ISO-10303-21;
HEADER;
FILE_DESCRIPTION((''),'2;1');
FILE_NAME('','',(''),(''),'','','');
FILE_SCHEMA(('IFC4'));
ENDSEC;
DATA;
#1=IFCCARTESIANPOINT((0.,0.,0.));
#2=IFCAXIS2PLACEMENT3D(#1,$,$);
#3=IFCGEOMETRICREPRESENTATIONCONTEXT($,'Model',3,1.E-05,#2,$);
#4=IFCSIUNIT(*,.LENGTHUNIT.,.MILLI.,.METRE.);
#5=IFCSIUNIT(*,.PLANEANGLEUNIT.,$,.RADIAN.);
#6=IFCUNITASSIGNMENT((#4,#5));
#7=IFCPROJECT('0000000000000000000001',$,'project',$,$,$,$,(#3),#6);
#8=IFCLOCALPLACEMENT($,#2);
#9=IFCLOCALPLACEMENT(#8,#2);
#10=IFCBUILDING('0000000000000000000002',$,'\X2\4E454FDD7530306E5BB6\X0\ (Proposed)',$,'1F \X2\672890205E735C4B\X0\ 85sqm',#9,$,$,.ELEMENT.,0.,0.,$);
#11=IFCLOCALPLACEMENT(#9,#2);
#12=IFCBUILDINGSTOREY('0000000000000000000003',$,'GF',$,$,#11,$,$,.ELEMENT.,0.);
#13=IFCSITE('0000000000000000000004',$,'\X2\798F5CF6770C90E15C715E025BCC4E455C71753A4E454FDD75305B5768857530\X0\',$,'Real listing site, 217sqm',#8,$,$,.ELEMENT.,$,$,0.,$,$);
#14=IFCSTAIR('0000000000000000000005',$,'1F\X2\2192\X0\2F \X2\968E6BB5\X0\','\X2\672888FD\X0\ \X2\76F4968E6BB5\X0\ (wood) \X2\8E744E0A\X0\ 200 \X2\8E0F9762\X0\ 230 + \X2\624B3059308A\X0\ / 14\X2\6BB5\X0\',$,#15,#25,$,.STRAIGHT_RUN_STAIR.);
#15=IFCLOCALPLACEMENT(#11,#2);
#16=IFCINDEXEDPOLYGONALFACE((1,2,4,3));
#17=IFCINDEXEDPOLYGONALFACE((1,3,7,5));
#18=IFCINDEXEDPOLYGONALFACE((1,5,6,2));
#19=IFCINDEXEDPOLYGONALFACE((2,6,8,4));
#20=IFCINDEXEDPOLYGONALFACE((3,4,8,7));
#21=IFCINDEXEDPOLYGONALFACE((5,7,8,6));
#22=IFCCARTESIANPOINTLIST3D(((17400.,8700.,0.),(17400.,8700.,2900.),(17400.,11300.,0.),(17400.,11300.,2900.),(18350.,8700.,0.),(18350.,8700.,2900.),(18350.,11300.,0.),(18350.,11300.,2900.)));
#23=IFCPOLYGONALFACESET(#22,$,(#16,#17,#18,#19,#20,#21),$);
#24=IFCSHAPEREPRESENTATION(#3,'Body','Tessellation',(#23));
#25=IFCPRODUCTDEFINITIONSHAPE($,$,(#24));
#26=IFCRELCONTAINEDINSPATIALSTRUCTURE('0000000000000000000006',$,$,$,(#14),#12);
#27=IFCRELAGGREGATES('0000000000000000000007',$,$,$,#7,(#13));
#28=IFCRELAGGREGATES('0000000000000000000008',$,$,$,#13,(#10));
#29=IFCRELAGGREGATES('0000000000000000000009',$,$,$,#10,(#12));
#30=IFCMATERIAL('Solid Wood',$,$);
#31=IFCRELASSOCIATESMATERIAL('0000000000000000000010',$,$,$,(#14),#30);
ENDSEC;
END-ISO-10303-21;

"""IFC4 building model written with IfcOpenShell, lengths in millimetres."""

from ifc_helpers import new_model, si_unit, frame, frame_2d, origin, place, context, project, spatial, rectangle, extrude, material, element, save


model = new_model("IFC4")

# Units and contexts
model_context = context("Model", 3, precision=1e-05, world=origin())
ifc_project = project(units=[si_unit("LENGTHUNIT", "METRE", prefix="MILLI"), si_unit("PLANEANGLEUNIT", "RADIAN")], contexts=[model_context])

# Site, building, storey
site_placement = place(None, origin())
site = spatial("IfcSite", under=ifc_project, at=site_placement, Name="福島県郡山市富久山町久保田字梅田", ObjectType="Real listing site, 217sqm", CompositionType="ELEMENT", RefElevation=0.0)
building_placement = place(site_placement, origin())
building = spatial("IfcBuilding", under=site, at=building_placement, Name="久保田の家 (Proposed)", ObjectType="1F 木造平屋 85sqm", CompositionType="ELEMENT", ElevationOfRefHeight=0.0, ElevationOfTerrain=0.0)
storey_placement = place(building_placement, origin())
storey = spatial("IfcBuildingStorey", under=building, at=storey_placement, Name="GF", CompositionType="ELEMENT", Elevation=0.0)

# Shared definitions
ifc_material_1 = material(Name="Solid Wood")

# Stair
stair_placement = place(storey_placement, frame((8700.0, 4350.0, 0.0)))
element("IfcStair", 1, at=stair_placement, inside=storey, material=ifc_material_1, Name="1F→2F 階段", Description="木製 直階段 (wood) 蹴上 200 踏面 230 + 手すり / 14段", PredefinedType="STRAIGHT_RUN_STAIR", context=model_context, shape_type="SweptSolid", body=[
    extrude(rectangle(XDim=950.0, YDim=2600.0, at=frame_2d((475.0, 1300.0))), frame((8700.0, 4350.0, 0.0)), (0.0, 0.0, 1.0), 2900.0),
])

save(model, "model.ifc")
